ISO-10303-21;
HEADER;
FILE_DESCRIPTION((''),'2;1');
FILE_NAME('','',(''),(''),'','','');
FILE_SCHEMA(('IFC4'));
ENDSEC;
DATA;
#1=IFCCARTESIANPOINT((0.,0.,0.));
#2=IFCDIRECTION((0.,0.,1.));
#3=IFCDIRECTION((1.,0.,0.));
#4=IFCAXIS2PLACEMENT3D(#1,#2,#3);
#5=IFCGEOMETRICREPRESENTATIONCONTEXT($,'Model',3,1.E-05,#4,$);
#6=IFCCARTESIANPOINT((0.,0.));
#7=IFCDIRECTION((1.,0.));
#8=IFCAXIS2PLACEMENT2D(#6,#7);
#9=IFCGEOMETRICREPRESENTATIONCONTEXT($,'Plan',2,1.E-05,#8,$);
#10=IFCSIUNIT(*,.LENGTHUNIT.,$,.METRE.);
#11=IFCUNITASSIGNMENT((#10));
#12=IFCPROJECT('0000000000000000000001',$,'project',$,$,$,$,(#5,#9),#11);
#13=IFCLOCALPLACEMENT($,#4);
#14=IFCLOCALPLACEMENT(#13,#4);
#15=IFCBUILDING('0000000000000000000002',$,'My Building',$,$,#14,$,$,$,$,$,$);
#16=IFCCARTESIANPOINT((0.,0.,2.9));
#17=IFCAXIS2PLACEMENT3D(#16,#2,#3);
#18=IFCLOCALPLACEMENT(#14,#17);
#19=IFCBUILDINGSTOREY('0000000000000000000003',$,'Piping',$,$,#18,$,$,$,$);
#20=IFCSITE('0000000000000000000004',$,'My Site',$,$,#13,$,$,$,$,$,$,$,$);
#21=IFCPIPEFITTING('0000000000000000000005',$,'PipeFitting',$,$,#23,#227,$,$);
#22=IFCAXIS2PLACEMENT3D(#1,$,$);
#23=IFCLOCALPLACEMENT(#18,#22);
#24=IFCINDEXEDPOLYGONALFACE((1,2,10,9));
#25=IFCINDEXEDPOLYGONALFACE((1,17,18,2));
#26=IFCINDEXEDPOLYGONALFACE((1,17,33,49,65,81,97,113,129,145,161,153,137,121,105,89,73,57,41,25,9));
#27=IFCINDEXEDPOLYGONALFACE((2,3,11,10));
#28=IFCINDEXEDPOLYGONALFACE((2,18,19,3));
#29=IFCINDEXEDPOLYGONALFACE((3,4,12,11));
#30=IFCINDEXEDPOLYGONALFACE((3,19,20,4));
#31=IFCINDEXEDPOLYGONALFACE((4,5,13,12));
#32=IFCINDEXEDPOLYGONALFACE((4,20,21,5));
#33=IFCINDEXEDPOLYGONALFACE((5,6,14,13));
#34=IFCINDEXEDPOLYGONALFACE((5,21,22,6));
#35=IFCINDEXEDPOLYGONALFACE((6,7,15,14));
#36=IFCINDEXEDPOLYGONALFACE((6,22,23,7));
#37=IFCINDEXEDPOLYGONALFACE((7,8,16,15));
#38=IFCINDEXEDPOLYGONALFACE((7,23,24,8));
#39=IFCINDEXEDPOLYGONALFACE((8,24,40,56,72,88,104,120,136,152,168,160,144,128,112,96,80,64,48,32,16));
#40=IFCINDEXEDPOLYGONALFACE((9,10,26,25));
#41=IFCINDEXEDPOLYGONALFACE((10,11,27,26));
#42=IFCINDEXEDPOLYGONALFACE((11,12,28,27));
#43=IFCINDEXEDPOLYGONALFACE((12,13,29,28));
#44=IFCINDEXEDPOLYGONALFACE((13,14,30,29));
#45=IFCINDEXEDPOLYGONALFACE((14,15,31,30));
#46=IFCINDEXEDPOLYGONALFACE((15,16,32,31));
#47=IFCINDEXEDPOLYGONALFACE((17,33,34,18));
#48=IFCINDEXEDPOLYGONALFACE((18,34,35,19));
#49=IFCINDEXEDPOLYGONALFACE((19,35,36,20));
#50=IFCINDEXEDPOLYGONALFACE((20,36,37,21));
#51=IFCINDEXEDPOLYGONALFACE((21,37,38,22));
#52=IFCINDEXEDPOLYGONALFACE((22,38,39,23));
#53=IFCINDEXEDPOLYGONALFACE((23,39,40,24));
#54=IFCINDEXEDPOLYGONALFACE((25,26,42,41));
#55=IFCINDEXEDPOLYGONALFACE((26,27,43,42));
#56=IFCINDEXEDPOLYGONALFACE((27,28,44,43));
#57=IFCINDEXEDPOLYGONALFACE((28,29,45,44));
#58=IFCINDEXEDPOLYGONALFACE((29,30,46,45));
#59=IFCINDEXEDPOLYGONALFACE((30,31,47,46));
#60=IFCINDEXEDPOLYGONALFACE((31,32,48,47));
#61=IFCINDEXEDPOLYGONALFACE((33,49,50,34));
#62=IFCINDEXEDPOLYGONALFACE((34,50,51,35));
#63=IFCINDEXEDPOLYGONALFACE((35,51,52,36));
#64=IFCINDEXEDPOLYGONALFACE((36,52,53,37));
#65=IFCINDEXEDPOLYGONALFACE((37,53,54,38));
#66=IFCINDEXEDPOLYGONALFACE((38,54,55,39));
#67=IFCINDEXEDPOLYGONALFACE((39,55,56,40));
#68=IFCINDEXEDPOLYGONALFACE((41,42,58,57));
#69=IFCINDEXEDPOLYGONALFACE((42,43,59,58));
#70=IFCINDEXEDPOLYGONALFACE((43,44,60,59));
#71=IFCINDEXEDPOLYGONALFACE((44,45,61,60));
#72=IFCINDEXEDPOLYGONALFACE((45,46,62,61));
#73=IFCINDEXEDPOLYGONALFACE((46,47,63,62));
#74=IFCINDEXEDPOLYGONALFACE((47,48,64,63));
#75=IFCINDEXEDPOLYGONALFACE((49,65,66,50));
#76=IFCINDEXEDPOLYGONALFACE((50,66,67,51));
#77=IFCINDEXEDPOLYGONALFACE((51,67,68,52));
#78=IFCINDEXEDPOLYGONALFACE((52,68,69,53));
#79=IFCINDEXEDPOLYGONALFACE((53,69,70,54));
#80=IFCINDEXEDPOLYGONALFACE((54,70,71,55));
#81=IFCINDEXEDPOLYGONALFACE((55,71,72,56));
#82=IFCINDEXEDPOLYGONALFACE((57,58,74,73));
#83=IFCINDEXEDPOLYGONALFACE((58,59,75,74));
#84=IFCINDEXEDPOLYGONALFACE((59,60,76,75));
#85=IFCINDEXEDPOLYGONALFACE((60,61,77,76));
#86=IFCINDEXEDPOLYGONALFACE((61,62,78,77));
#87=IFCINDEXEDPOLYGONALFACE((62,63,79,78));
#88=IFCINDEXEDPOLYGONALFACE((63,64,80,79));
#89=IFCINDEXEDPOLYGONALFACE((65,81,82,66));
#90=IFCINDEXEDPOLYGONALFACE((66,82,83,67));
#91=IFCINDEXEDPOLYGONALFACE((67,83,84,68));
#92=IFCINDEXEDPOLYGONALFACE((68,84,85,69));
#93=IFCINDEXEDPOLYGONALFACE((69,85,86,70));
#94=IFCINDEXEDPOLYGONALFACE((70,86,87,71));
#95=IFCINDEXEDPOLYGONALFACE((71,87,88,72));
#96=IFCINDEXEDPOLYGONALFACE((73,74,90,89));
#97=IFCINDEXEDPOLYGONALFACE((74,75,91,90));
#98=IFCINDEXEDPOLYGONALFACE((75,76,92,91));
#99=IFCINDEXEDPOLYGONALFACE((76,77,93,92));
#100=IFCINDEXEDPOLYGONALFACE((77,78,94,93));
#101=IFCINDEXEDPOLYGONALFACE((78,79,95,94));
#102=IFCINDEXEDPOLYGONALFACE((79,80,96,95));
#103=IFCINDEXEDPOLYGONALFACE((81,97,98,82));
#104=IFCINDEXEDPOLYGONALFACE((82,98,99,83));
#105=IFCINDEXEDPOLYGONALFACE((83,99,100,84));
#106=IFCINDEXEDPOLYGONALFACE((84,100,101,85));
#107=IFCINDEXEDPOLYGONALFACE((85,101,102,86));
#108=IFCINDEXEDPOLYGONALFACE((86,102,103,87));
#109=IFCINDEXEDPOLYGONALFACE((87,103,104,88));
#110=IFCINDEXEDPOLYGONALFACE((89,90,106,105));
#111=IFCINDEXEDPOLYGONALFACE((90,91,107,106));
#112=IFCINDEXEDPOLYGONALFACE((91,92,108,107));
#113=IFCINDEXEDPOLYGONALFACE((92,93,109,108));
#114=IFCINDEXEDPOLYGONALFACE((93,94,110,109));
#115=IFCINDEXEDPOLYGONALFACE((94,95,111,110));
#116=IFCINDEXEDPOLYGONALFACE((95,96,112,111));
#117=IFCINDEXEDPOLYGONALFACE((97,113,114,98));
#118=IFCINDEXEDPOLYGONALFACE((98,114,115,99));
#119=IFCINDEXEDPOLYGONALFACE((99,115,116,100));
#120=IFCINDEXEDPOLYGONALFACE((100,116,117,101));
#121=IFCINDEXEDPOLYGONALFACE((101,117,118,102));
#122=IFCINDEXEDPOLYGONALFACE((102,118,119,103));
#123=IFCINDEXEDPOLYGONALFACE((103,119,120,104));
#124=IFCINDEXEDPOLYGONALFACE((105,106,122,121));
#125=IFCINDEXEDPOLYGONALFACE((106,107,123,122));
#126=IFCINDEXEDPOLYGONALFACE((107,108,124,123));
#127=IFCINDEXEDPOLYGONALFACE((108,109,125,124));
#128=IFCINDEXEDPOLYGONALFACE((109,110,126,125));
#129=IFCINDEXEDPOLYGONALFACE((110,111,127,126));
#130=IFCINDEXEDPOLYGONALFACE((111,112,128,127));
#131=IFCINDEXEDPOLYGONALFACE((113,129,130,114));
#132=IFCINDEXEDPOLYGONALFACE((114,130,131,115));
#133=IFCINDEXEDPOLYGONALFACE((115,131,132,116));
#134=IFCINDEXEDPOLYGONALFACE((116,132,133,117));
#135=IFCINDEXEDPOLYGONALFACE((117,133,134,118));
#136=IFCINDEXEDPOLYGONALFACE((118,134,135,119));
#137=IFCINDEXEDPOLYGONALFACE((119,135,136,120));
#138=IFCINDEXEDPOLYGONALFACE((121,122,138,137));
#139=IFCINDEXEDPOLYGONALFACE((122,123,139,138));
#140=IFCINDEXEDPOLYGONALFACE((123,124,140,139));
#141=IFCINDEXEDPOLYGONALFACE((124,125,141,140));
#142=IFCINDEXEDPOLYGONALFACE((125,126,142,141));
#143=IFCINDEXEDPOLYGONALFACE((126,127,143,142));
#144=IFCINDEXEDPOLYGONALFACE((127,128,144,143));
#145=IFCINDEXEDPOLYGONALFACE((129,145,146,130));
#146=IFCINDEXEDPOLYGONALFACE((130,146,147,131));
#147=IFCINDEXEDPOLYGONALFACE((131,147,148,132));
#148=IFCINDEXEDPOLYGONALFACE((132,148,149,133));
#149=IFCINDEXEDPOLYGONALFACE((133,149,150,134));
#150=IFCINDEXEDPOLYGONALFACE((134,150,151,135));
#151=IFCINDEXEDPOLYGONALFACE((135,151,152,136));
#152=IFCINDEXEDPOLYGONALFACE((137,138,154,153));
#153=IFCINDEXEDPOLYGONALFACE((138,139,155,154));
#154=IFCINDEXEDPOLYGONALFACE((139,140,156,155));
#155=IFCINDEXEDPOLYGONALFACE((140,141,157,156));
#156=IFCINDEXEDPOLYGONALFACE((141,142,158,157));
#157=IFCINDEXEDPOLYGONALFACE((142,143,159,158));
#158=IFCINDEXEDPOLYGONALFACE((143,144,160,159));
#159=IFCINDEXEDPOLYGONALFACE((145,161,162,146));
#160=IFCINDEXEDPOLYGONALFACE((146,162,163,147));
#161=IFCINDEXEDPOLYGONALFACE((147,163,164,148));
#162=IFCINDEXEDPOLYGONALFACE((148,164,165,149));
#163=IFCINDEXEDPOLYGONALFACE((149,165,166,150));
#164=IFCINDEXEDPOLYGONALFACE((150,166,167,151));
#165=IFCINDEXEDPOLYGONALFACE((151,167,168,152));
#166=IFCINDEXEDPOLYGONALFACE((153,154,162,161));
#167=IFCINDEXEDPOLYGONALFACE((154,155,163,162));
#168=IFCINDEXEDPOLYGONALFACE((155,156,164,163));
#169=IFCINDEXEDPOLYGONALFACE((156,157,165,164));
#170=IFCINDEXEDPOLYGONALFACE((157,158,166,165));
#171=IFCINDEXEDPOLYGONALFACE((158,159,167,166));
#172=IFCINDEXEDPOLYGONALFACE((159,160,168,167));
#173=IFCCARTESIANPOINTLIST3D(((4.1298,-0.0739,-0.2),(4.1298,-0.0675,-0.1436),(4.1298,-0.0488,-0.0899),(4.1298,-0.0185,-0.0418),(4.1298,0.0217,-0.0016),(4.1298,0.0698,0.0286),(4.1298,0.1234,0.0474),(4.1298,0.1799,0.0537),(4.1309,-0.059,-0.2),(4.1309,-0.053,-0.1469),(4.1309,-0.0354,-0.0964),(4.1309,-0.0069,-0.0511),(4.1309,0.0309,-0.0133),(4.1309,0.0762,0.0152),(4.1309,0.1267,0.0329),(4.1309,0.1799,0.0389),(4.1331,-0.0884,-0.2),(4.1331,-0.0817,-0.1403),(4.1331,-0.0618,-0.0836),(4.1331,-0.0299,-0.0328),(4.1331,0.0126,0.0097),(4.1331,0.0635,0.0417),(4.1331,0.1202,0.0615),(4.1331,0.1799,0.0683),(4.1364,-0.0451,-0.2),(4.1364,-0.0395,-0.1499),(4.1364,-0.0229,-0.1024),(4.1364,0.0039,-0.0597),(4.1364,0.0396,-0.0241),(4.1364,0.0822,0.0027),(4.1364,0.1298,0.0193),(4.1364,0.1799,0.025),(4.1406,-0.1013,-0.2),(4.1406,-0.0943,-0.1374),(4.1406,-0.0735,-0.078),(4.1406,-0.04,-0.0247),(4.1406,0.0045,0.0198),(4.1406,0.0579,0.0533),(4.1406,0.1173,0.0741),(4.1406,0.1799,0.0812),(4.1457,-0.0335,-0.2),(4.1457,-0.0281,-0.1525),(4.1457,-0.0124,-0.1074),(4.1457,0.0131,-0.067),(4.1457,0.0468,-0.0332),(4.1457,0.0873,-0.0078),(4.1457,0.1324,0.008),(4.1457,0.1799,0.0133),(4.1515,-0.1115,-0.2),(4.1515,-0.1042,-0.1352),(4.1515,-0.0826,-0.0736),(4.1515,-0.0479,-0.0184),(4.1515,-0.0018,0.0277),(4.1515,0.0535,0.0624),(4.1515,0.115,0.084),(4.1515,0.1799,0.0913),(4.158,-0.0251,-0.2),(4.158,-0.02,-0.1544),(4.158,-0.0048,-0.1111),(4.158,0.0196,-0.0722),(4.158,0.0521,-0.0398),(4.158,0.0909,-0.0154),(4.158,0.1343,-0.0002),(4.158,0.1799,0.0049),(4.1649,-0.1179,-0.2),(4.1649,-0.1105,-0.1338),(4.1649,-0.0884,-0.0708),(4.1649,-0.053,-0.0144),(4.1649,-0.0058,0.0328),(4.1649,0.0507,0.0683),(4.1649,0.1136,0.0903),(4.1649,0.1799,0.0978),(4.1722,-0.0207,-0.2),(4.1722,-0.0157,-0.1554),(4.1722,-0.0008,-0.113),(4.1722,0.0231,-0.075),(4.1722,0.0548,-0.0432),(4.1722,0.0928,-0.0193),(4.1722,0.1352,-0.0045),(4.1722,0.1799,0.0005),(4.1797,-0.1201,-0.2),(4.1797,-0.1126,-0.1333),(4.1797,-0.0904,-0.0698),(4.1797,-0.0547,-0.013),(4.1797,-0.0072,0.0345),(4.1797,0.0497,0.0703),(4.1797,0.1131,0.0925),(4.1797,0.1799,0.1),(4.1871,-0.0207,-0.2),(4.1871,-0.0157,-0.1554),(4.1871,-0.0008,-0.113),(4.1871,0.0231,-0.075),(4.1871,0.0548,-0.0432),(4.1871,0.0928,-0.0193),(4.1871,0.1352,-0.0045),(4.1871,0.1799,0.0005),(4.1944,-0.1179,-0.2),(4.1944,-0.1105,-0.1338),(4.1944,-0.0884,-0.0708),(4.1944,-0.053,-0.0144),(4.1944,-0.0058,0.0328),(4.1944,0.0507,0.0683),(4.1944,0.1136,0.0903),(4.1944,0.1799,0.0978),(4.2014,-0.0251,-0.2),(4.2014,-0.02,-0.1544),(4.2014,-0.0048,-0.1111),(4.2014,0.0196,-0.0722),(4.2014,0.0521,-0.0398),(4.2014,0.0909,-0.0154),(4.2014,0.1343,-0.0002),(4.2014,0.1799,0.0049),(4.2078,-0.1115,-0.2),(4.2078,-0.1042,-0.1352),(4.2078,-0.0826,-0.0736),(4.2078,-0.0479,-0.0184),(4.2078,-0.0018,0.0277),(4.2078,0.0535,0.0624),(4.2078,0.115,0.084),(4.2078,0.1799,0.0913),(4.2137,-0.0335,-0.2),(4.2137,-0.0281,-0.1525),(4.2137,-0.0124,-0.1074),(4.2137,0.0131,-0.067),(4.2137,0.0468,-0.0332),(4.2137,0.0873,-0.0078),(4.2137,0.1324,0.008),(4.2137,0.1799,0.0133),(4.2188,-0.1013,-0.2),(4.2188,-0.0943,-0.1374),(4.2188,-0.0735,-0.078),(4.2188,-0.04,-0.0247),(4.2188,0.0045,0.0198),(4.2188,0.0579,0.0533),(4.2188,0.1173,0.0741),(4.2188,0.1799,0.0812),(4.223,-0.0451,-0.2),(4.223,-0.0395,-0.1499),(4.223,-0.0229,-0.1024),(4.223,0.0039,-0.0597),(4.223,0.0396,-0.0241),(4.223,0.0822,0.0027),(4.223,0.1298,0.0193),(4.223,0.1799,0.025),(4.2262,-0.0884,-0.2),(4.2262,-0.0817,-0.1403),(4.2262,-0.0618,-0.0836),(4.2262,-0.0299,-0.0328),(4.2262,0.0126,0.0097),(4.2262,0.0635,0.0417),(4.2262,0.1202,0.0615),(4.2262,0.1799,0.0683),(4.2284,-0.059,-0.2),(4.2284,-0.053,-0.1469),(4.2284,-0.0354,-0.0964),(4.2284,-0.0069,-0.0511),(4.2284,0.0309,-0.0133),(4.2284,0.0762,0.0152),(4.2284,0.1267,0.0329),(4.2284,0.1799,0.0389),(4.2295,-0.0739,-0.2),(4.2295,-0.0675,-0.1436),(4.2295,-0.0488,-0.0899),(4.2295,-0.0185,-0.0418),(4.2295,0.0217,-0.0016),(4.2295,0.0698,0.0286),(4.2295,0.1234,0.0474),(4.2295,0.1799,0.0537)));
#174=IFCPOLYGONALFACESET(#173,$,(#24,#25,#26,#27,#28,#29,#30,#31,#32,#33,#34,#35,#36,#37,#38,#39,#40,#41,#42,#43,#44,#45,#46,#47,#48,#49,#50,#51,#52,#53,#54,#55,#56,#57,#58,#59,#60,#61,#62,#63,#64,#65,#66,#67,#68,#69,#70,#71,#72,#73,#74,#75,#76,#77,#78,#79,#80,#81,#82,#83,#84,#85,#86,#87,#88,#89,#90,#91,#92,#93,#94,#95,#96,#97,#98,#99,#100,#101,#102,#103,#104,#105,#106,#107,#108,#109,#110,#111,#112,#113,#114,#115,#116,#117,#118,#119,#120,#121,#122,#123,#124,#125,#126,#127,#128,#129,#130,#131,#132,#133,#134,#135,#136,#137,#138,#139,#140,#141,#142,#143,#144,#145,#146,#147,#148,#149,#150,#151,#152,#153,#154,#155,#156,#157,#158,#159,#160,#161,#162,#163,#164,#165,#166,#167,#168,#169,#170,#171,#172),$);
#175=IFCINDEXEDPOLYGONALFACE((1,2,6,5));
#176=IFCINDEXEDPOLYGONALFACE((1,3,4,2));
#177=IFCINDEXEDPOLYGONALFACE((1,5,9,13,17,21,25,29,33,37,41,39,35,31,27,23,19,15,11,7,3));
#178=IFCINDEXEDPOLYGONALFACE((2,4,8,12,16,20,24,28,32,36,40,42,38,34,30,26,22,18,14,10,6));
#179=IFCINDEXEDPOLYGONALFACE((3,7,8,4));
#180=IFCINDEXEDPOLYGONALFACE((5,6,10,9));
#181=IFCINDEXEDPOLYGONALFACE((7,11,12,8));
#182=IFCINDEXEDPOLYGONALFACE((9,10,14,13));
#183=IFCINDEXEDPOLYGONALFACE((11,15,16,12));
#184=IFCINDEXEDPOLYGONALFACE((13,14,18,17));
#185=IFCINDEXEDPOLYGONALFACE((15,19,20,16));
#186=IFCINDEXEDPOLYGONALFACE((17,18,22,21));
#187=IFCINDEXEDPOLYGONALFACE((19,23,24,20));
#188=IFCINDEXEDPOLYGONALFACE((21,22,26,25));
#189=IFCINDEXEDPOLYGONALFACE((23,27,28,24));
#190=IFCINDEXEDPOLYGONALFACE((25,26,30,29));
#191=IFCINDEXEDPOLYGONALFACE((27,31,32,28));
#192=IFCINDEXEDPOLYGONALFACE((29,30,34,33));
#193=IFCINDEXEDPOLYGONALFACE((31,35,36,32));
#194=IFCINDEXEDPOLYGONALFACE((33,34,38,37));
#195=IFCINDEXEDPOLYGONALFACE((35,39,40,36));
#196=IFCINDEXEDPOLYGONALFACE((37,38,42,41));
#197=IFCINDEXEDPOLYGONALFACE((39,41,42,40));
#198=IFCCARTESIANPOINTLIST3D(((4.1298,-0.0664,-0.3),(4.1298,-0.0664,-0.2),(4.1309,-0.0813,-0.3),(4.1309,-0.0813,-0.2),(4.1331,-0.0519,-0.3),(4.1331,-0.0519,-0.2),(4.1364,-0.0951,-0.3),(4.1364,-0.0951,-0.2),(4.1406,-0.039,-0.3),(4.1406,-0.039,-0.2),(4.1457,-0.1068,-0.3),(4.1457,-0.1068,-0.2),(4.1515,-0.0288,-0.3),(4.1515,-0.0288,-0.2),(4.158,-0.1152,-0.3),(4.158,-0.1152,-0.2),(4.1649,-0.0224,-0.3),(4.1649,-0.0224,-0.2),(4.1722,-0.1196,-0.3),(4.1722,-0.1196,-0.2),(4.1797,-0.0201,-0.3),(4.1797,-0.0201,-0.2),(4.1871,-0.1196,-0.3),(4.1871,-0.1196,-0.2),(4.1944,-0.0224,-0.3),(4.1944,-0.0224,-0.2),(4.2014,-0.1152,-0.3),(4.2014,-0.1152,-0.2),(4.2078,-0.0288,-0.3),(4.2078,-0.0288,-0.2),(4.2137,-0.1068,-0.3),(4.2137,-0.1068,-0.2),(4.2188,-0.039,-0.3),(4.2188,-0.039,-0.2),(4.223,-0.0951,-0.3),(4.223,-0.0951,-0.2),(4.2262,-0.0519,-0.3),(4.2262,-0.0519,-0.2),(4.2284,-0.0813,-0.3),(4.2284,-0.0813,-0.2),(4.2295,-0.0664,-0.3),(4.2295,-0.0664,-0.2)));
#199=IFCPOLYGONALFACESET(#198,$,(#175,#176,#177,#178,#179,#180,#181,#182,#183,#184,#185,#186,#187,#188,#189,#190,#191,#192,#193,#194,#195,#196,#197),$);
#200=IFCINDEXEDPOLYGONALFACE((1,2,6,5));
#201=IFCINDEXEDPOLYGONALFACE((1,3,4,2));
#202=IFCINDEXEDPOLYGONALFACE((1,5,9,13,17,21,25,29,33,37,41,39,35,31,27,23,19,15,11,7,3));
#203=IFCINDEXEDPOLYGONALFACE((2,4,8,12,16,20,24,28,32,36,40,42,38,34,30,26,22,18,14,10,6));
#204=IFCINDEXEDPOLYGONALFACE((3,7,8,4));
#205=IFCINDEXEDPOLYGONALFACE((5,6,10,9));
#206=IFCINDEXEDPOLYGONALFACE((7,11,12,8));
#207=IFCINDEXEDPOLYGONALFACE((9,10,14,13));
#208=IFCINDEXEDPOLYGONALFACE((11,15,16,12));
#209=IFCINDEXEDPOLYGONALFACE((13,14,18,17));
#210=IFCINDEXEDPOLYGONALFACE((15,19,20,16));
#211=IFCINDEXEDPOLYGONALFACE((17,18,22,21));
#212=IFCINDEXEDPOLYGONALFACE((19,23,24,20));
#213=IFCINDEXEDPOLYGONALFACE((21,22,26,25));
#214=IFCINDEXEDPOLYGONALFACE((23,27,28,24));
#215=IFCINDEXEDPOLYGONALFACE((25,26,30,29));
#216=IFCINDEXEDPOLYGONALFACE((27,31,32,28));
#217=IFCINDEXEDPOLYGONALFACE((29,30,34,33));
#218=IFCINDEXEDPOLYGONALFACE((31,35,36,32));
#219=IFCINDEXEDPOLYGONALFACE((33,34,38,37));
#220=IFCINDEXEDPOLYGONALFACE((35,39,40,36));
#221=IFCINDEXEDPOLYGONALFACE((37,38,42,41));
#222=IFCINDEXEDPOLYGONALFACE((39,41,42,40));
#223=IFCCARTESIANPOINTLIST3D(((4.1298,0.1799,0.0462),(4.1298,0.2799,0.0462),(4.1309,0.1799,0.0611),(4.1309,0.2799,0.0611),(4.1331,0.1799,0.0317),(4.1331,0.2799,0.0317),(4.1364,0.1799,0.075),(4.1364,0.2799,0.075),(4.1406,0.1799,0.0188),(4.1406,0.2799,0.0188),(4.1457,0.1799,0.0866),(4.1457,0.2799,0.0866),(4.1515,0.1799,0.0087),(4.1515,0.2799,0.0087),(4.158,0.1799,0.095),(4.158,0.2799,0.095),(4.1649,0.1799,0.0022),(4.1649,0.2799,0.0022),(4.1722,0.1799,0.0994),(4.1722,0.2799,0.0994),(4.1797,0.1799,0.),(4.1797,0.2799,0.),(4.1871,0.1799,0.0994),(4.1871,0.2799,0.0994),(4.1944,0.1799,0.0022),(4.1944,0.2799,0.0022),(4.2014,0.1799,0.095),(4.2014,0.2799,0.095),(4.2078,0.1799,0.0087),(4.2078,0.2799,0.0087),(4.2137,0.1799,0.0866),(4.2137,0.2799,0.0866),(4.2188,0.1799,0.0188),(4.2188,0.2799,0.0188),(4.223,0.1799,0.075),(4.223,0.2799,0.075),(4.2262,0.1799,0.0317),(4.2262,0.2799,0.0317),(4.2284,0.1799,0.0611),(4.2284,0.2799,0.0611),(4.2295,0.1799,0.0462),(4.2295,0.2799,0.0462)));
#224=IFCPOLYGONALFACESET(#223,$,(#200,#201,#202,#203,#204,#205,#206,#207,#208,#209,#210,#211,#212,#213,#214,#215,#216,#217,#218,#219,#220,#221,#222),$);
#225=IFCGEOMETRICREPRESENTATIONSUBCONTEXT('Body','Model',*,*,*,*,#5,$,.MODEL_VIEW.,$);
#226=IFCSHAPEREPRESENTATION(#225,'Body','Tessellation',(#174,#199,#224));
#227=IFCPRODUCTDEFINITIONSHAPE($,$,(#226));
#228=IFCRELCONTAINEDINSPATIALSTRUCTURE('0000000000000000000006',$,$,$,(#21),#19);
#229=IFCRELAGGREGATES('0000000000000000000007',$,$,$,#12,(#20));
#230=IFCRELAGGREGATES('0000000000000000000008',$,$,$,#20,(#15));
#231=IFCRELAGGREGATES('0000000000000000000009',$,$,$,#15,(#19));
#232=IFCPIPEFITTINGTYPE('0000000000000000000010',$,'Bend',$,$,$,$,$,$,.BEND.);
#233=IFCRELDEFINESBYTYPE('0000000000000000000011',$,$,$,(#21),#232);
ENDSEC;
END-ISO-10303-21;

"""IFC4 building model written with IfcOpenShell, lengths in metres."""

from ifc_helpers import new_model, entity, si_unit, frame, origin_with_axes, origin_2d_with_axis, place, context, subcontext, project, spatial, circle, extrude, source, transform, mapped, type_object, type_shapes, element, save


model = new_model("IFC4")

# Units and contexts
model_context = context("Model", 3, precision=1e-05, world=origin_with_axes())
plan_context = context("Plan", 2, precision=1e-05, world=origin_2d_with_axis())
body_context = subcontext(model_context, "Body", "Model", "MODEL_VIEW")
ifc_project = project(units=[si_unit("LENGTHUNIT", "METRE")], contexts=[model_context, plan_context])

# Site, building, storey
site_placement = place(None, origin_with_axes())
site = spatial("IfcSite", under=ifc_project, at=site_placement, Name="My Site")
building_placement = place(site_placement, origin_with_axes())
building = spatial("IfcBuilding", under=site, at=building_placement, Name="My Building")
storey_placement = place(building_placement, frame((0.0, 0.0, 2.9), z_axis=(0.0, 0.0, 1.0), x_axis=(1.0, 0.0, 0.0)))
storey = spatial("IfcBuildingStorey", under=building, at=storey_placement, Name="Piping")

# Pipe fitting
pipe_fitting_type_1 = type_object("IfcPipeFittingType", Name="Bend", PredefinedType="BEND")
shared_shape = source(origin_with_axes(), body_context, "Body", "SolidModel", [
    entity("IfcSweptDiskSolid", entity("IfcIndexedPolyCurve", entity("IfcCartesianPointList3D", [[0.0, 0.0, -0.1], [0.0732, 0.0, -0.2768], [0.25, 0.0, -0.35]]), [entity("IfcArcIndex", [1, 2, 3])]), 0.05),
    extrude(circle(Radius=0.05), origin_with_axes(), (0.0, 0.0, -1.0), 0.1),
    extrude(circle(Radius=0.05), frame((0.25, 0.0, -0.35), z_axis=(1.0, 0.0, 0.0), x_axis=(0.0, 0.0, 1.0)), (0.0, 0.0, 1.0), 0.1),
])
type_shapes(pipe_fitting_type_1, [shared_shape])
for number, where, z_axis, x_axis, name in (
    (1, (4.1797, -0.0701, -0.3), (0.0, 0.0, -1.0), (0.0, 1.0, 0.0), "PipeFitting"),
):
    element("IfcPipeFitting", number, at=place(storey_placement, frame(where, z_axis=z_axis, x_axis=x_axis)), inside=storey, type_object=pipe_fitting_type_1, Name=name, context=body_context, shape_type="MappedRepresentation", body=[
        mapped(shared_shape, transform((0.0, 0.0, 0.0), x_axis=(1.0, 0.0, 0.0), y_axis=(0.0, 1.0, 0.0), z_axis=(0.0, 0.0, 1.0), scale=1.0)),
    ])

save(model, "model.ifc")
